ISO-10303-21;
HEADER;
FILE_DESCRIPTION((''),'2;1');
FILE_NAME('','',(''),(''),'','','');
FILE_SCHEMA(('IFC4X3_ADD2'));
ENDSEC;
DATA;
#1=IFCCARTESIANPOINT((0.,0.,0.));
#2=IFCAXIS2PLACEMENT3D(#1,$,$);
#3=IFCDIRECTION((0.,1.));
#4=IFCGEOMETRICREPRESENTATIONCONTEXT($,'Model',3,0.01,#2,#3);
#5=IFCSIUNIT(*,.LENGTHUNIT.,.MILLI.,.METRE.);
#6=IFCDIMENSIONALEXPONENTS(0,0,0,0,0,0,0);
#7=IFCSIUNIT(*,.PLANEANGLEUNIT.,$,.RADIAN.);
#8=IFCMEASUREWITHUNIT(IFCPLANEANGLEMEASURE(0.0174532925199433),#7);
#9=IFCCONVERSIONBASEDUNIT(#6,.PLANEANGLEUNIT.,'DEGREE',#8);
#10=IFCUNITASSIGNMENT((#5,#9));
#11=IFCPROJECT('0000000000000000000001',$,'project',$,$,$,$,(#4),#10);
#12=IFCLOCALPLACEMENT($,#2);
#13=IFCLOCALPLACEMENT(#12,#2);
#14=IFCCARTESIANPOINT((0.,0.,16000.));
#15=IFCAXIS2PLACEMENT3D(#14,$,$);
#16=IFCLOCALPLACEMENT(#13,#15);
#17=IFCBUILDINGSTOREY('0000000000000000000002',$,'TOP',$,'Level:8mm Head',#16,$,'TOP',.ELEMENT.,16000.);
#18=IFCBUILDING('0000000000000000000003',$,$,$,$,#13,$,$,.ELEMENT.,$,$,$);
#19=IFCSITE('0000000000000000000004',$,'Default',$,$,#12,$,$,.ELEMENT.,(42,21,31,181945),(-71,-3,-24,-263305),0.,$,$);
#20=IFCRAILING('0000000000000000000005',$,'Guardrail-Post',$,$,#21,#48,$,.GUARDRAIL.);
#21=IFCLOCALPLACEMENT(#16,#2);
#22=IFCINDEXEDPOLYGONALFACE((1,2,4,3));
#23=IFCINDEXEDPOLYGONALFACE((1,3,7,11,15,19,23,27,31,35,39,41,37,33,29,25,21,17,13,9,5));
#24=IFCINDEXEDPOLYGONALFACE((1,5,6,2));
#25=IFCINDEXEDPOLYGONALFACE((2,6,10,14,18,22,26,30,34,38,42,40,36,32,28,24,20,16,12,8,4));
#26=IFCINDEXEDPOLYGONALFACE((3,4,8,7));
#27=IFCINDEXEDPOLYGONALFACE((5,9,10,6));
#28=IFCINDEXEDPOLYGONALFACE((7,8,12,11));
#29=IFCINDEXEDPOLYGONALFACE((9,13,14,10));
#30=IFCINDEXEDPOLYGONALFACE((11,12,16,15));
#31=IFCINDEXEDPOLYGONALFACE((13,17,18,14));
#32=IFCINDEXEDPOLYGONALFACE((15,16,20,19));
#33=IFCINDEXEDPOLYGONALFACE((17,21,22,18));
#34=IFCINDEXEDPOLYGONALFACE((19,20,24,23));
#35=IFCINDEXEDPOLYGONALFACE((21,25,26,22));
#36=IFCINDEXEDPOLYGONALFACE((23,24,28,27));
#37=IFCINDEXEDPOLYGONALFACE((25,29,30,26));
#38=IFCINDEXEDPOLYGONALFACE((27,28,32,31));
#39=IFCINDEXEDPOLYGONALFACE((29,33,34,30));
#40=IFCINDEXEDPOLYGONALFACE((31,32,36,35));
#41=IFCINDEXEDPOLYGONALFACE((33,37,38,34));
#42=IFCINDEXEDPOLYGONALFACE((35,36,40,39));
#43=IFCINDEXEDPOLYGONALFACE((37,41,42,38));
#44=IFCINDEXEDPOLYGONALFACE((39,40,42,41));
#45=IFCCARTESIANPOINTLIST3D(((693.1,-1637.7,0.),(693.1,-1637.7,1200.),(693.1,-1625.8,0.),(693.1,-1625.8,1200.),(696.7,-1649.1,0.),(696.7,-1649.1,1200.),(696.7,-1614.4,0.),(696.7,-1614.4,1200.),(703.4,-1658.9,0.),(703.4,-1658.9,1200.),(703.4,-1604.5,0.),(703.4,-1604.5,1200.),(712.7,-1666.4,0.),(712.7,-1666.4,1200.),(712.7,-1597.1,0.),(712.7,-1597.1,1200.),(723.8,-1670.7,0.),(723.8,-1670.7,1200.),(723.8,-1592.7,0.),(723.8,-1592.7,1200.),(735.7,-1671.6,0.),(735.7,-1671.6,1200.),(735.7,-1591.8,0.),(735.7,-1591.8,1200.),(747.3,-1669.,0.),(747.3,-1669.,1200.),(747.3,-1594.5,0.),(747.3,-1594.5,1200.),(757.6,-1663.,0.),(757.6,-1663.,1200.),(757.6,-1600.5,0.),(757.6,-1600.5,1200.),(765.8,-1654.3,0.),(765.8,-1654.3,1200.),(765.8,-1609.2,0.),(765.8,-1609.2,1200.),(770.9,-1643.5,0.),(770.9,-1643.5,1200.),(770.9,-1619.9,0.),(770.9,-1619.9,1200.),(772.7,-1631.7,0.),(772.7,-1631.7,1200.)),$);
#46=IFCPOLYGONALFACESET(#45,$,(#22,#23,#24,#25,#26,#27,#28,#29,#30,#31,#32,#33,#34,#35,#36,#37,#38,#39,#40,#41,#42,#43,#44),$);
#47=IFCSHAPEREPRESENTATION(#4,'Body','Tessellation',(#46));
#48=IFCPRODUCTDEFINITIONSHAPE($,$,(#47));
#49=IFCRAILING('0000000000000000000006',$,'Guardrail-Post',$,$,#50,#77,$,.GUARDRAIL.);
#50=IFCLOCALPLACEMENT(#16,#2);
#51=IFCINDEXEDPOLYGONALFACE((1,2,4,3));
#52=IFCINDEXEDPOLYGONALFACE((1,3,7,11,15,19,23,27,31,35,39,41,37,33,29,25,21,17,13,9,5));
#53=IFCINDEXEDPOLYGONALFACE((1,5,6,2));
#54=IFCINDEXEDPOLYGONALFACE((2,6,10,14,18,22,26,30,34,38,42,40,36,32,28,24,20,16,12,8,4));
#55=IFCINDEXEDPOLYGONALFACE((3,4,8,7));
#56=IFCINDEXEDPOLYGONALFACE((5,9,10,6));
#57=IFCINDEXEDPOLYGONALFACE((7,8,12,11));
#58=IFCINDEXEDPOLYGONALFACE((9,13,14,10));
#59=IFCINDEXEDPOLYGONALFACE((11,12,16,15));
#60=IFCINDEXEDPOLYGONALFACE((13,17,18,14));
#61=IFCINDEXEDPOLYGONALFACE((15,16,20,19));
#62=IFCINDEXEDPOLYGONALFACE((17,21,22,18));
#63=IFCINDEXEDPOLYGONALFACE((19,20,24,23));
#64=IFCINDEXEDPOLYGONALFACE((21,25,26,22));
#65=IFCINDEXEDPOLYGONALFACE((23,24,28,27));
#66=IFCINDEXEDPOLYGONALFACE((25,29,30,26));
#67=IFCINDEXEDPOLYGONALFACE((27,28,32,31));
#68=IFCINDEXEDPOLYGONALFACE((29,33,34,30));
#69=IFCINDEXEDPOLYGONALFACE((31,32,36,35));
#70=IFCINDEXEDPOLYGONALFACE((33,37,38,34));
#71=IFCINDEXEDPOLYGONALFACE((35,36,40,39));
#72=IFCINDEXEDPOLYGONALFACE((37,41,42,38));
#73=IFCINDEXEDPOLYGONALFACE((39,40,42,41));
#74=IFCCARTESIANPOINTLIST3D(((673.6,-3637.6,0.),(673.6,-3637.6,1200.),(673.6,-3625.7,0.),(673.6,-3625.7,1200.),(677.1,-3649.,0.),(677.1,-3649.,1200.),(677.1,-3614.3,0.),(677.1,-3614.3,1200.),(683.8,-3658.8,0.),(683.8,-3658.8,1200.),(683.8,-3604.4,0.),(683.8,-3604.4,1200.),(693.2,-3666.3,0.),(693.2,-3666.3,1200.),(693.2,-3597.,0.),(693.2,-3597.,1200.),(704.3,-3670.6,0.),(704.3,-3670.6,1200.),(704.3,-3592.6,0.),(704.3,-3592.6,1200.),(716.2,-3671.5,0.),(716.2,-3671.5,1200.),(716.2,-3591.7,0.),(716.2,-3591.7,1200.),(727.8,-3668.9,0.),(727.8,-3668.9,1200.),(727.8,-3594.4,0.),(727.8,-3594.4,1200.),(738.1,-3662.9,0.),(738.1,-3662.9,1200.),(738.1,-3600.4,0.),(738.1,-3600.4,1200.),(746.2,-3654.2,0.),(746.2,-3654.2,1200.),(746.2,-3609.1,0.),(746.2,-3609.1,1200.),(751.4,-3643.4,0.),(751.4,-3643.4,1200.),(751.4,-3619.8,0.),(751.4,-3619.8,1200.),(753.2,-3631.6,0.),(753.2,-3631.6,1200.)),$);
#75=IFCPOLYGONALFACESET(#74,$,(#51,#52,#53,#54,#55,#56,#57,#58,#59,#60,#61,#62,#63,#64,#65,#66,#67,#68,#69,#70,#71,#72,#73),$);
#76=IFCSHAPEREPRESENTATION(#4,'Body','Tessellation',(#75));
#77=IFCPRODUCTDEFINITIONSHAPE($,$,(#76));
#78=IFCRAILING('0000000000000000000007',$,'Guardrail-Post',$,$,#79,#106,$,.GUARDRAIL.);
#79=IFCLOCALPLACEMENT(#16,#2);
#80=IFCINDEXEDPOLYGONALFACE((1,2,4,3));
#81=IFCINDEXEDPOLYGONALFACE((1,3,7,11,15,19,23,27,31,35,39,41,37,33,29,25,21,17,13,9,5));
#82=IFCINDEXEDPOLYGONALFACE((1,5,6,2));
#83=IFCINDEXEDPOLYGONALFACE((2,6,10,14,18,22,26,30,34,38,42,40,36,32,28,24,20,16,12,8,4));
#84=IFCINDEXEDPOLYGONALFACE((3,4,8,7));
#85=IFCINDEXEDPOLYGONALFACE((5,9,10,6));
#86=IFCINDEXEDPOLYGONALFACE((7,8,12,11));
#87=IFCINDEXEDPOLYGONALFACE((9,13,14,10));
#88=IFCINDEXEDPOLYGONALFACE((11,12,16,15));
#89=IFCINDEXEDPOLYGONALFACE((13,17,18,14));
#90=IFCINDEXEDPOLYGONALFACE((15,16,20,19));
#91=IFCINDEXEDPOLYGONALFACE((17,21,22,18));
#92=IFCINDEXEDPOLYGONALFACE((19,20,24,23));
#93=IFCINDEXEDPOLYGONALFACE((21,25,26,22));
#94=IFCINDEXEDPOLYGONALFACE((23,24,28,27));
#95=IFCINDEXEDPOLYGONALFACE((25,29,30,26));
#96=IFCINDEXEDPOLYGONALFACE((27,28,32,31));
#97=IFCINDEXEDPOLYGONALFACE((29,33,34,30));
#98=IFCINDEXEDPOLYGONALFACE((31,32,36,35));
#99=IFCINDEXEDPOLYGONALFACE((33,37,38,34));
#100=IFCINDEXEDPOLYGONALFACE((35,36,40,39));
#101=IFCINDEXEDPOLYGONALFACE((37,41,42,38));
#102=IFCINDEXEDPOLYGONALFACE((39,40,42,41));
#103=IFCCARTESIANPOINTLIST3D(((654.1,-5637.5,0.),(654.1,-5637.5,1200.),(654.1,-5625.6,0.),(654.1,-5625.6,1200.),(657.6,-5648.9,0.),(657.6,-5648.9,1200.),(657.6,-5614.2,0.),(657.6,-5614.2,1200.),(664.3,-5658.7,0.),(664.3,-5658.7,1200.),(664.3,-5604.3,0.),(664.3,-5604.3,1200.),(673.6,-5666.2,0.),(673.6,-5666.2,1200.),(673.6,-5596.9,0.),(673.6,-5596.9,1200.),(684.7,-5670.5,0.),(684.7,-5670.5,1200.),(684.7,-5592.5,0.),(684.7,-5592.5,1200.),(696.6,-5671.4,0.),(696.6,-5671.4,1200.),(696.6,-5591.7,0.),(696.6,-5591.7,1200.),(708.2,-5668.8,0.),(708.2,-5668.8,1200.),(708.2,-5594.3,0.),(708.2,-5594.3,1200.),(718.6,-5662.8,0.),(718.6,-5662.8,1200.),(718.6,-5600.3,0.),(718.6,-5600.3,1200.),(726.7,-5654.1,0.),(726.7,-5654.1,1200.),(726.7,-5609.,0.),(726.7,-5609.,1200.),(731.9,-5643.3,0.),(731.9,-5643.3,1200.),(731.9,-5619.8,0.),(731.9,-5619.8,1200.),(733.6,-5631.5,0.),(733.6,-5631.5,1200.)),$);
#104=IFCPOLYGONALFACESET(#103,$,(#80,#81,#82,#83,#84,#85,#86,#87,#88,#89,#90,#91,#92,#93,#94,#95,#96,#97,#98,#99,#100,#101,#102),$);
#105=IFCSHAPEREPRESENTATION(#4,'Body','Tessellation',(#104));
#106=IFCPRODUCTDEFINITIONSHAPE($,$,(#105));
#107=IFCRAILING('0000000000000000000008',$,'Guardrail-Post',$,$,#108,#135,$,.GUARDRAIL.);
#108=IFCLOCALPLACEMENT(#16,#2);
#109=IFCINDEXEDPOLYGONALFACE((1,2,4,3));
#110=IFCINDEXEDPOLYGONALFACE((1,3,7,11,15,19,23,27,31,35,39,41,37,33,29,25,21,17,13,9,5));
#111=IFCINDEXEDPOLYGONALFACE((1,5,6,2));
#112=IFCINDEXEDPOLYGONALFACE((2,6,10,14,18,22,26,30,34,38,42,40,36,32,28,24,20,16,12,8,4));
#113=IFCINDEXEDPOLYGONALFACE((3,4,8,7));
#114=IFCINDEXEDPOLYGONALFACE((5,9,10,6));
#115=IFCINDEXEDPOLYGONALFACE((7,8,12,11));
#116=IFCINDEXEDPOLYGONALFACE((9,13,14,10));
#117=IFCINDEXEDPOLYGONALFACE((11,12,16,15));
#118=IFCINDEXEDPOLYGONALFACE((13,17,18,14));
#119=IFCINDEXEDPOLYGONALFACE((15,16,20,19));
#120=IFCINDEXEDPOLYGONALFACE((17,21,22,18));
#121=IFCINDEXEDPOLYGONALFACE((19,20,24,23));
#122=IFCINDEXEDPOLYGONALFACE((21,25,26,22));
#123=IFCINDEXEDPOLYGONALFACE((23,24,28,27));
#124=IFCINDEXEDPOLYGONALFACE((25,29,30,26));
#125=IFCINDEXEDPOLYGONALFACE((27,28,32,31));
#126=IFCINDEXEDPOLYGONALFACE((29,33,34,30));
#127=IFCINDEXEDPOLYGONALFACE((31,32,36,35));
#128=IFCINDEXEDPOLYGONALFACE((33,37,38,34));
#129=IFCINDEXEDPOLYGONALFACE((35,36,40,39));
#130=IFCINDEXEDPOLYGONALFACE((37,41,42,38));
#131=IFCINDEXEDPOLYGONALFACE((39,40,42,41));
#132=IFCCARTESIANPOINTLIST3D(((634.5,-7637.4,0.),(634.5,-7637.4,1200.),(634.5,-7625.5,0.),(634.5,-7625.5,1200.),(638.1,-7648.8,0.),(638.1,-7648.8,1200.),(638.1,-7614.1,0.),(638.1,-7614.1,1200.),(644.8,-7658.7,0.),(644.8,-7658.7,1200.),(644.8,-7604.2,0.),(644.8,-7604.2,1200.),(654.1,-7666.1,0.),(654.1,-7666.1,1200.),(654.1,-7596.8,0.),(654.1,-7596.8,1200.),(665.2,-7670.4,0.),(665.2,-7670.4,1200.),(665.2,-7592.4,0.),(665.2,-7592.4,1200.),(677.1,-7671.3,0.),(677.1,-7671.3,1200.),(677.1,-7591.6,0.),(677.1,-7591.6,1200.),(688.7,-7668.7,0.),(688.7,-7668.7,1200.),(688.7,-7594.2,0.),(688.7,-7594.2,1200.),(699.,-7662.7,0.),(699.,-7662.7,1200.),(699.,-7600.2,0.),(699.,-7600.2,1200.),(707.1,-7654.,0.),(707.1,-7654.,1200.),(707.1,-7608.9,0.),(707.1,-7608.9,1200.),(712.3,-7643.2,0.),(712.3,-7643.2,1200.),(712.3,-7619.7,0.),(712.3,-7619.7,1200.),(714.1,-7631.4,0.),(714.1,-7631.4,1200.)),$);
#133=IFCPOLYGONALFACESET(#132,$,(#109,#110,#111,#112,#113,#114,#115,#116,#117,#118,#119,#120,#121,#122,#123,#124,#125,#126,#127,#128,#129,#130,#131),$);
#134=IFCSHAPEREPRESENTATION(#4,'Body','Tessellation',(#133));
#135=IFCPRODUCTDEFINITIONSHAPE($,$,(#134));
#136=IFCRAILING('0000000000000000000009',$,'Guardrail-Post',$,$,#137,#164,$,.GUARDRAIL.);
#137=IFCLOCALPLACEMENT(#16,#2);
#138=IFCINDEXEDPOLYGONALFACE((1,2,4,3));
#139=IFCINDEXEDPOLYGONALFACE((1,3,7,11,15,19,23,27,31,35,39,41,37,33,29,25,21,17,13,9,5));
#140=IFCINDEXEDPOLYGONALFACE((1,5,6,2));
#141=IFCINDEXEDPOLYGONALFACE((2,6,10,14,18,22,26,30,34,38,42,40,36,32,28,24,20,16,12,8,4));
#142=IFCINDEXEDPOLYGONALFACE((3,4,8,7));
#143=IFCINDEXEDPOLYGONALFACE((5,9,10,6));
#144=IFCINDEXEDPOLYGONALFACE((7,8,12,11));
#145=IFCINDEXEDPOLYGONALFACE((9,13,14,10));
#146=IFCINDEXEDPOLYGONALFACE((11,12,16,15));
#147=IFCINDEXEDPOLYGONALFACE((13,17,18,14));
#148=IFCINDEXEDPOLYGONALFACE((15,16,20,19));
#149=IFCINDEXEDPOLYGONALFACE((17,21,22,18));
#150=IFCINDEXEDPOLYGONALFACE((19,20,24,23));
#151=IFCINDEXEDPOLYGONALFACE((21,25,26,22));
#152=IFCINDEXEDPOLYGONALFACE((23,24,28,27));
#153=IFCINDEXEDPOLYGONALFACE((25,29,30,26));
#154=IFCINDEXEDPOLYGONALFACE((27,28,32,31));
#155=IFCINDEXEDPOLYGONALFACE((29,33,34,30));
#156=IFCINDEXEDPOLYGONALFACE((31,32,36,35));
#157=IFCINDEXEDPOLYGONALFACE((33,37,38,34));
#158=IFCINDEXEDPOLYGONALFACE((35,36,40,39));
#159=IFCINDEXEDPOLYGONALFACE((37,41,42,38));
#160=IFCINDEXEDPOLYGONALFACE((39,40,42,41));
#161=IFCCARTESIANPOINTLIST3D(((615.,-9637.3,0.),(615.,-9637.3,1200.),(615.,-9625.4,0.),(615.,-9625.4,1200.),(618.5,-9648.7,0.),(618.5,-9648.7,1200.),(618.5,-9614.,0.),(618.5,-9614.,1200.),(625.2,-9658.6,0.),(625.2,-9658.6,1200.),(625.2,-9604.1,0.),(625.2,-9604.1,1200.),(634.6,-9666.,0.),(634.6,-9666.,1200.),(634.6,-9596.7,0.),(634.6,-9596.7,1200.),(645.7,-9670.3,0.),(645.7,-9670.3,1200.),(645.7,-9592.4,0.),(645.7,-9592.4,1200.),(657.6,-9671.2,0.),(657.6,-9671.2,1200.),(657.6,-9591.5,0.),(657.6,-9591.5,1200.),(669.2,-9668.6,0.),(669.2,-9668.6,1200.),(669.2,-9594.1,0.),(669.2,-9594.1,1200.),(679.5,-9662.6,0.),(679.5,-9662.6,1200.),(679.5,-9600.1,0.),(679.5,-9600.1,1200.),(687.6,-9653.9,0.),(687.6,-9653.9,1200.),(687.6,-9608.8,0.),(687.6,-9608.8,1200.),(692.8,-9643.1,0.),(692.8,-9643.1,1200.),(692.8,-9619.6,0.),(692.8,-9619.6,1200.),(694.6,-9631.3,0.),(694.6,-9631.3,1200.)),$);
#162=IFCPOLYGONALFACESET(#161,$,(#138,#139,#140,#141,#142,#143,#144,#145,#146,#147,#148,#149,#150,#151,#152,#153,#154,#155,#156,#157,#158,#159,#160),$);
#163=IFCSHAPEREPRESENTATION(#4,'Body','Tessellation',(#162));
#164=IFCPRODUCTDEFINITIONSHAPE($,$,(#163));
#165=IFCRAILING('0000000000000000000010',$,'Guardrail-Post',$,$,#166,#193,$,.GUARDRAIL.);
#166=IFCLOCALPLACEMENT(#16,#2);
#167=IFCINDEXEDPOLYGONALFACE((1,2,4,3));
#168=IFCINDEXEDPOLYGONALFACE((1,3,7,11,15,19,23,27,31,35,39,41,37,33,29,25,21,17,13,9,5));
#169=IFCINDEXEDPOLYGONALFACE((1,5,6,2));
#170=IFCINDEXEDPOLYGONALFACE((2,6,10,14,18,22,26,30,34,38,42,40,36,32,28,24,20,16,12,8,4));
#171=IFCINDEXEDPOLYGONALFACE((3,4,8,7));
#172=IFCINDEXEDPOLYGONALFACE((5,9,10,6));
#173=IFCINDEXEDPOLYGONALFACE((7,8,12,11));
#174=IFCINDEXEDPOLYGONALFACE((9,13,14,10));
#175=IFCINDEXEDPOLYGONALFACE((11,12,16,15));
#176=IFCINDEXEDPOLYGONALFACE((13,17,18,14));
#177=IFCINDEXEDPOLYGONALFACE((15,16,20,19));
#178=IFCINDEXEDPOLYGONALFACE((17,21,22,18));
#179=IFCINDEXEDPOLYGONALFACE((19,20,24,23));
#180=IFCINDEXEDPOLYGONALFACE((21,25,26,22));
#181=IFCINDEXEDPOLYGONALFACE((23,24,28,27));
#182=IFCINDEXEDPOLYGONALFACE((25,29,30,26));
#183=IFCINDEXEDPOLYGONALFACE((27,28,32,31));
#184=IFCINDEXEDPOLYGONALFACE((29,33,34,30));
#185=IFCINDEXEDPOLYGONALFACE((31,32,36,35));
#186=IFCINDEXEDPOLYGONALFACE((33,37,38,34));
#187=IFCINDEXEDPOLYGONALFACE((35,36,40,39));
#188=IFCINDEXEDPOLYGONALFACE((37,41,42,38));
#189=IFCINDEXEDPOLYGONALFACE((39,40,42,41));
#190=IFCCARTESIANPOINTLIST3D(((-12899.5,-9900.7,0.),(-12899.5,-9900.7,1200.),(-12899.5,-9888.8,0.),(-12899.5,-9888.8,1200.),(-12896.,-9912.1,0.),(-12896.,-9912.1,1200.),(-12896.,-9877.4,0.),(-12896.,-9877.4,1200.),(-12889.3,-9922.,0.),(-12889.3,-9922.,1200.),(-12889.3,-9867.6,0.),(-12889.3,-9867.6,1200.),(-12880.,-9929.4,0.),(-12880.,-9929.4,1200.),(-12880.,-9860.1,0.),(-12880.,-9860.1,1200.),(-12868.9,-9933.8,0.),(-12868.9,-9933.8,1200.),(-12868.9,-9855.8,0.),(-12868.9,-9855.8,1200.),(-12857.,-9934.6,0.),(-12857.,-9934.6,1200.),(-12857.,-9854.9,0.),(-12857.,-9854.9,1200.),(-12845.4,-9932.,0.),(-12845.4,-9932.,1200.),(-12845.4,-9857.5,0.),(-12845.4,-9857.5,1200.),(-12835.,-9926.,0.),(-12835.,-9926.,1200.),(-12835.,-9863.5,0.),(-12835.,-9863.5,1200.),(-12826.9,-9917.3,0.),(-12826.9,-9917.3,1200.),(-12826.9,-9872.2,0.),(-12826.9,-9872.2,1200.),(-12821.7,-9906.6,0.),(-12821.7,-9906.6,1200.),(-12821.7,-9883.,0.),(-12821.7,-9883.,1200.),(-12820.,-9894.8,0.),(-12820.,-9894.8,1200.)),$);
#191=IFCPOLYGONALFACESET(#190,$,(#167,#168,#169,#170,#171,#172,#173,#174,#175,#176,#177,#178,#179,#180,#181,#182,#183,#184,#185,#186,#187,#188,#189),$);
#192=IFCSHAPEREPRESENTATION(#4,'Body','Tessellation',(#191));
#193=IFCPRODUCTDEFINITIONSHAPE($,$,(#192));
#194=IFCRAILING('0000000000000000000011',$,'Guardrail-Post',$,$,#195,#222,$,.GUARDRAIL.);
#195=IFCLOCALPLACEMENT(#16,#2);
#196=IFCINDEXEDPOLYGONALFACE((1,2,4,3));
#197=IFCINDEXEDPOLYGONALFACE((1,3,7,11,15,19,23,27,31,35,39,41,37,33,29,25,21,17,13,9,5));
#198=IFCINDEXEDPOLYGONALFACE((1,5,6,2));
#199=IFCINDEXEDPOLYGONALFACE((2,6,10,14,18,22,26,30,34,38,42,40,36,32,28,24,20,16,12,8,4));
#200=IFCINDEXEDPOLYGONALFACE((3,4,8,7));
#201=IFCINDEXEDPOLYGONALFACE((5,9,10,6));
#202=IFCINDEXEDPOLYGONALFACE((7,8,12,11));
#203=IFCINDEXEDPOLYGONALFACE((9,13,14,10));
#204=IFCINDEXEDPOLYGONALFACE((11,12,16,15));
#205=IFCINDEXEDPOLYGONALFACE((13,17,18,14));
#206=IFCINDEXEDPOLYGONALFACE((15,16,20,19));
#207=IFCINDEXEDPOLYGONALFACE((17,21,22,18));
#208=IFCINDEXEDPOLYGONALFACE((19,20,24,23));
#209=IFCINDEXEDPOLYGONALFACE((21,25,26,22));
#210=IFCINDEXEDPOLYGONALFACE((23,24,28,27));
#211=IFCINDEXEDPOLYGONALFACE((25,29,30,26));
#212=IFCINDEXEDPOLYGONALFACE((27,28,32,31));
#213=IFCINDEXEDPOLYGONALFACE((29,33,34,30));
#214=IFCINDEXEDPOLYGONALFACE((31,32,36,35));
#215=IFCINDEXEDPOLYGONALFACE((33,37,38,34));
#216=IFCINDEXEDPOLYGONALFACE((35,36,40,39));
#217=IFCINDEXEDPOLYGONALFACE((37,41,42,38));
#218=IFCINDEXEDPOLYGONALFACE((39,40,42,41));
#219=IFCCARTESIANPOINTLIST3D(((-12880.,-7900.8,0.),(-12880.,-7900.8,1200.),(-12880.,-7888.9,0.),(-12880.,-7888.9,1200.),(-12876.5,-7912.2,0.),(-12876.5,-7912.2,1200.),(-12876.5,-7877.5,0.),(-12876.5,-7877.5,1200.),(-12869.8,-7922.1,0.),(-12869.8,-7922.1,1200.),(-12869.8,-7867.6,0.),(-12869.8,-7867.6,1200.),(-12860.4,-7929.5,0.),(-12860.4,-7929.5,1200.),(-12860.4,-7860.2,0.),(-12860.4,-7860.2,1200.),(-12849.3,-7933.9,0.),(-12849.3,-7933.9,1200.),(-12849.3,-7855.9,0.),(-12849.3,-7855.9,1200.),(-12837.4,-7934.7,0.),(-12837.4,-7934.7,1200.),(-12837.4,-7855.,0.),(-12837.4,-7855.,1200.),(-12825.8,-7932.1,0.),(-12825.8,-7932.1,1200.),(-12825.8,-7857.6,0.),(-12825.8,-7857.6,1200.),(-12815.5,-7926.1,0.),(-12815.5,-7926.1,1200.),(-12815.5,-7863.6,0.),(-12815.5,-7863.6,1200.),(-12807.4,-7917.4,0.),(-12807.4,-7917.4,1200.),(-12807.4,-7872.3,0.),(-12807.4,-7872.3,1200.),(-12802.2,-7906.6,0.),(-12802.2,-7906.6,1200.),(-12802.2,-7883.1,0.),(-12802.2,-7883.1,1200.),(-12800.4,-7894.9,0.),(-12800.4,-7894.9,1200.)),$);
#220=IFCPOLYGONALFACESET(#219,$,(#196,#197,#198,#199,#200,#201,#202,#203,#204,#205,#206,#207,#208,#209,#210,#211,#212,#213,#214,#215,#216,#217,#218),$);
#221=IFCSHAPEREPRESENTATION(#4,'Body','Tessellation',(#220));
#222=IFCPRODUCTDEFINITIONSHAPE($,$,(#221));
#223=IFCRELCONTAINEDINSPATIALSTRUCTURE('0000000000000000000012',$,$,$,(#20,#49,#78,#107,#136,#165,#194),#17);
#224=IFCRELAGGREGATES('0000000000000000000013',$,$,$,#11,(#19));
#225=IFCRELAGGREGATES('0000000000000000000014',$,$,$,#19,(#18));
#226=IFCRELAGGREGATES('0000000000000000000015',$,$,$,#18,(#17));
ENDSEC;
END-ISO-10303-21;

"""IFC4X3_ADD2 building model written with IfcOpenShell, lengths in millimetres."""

from ifc_helpers import new_model, entity, si_unit, converted_unit, direction, frame, origin, origin_with_axes, origin_2d, place, context, project, spatial, circle, extrude, element, save


model = new_model("IFC4X3_ADD2")

# Units and contexts
model_context = context("Model", 3, precision=0.01, world=origin(), true_north=direction((0.0, 1.0)))
ifc_project = project(units=[si_unit("LENGTHUNIT", "METRE", prefix="MILLI"), converted_unit("PLANEANGLEUNIT", "DEGREE", entity("IfcPlaneAngleMeasure", 0.0174532925199433), si_unit("PLANEANGLEUNIT", "RADIAN"), dimensions=[0, 0, 0, 0, 0, 0, 0])], contexts=[model_context])

# Site, building, storey
site_placement = place(None, origin())
site = spatial("IfcSite", under=ifc_project, at=site_placement, Name="Default", CompositionType="ELEMENT", RefLatitude=(42, 21, 31, 181945), RefLongitude=(-71, -3, -24, -263305), RefElevation=0.0)
building_placement = place(site_placement, origin())
building = spatial("IfcBuilding", under=site, at=building_placement, CompositionType="ELEMENT")
storey_placement = place(building_placement, frame((0.0, 0.0, 16000.0)))
storey = spatial("IfcBuildingStorey", under=building, at=storey_placement, Name="TOP", ObjectType="Level:8mm Head", LongName="TOP", CompositionType="ELEMENT", Elevation=16000.0)

# Railings
for number, where, z_axis, x_axis, name in (
    (1, (732.7, -1631.7, 16000.0), (0.0, 0.0, 1.0), (1.0, 0.0, 0.0), "Guardrail-Post"),
    (2, (713.2, -3631.6, 16000.0), (0.0, 0.0, 1.0), (1.0, 0.0, 0.0), "Guardrail-Post"),
    (3, (693.6, -5631.5, 16000.0), (0.0, 0.0, 1.0), (1.0, 0.0, 0.0), "Guardrail-Post"),
    (4, (674.1, -7631.4, 16000.0), (0.0, 0.0, 1.0), (1.0, 0.0, 0.0), "Guardrail-Post"),
    (5, (654.6, -9631.3, 16000.0), (0.0, 0.0, 1.0), (1.0, 0.0, 0.0), "Guardrail-Post"),
    (6, (-12860.0, -9894.8, 16000.0), (0.0, 0.0, 1.0), (1.0, 0.0, 0.0), "Guardrail-Post"),
    (7, (-12840.4, -7894.9, 16000.0), (0.0, 0.0, 1.0), (1.0, 0.0, 0.0), "Guardrail-Post"),
):
    element("IfcRailing", number, at=place(None, frame(where, z_axis=z_axis, x_axis=x_axis)), inside=storey, Name=name, PredefinedType="GUARDRAIL", context=model_context, shape_type="SweptSolid", body=[
        extrude(circle(Radius=40.0, at=origin_2d()), origin_with_axes(), (0.0, 0.0, 1.0), 1200.0),
    ])

save(model, "model.ifc")
